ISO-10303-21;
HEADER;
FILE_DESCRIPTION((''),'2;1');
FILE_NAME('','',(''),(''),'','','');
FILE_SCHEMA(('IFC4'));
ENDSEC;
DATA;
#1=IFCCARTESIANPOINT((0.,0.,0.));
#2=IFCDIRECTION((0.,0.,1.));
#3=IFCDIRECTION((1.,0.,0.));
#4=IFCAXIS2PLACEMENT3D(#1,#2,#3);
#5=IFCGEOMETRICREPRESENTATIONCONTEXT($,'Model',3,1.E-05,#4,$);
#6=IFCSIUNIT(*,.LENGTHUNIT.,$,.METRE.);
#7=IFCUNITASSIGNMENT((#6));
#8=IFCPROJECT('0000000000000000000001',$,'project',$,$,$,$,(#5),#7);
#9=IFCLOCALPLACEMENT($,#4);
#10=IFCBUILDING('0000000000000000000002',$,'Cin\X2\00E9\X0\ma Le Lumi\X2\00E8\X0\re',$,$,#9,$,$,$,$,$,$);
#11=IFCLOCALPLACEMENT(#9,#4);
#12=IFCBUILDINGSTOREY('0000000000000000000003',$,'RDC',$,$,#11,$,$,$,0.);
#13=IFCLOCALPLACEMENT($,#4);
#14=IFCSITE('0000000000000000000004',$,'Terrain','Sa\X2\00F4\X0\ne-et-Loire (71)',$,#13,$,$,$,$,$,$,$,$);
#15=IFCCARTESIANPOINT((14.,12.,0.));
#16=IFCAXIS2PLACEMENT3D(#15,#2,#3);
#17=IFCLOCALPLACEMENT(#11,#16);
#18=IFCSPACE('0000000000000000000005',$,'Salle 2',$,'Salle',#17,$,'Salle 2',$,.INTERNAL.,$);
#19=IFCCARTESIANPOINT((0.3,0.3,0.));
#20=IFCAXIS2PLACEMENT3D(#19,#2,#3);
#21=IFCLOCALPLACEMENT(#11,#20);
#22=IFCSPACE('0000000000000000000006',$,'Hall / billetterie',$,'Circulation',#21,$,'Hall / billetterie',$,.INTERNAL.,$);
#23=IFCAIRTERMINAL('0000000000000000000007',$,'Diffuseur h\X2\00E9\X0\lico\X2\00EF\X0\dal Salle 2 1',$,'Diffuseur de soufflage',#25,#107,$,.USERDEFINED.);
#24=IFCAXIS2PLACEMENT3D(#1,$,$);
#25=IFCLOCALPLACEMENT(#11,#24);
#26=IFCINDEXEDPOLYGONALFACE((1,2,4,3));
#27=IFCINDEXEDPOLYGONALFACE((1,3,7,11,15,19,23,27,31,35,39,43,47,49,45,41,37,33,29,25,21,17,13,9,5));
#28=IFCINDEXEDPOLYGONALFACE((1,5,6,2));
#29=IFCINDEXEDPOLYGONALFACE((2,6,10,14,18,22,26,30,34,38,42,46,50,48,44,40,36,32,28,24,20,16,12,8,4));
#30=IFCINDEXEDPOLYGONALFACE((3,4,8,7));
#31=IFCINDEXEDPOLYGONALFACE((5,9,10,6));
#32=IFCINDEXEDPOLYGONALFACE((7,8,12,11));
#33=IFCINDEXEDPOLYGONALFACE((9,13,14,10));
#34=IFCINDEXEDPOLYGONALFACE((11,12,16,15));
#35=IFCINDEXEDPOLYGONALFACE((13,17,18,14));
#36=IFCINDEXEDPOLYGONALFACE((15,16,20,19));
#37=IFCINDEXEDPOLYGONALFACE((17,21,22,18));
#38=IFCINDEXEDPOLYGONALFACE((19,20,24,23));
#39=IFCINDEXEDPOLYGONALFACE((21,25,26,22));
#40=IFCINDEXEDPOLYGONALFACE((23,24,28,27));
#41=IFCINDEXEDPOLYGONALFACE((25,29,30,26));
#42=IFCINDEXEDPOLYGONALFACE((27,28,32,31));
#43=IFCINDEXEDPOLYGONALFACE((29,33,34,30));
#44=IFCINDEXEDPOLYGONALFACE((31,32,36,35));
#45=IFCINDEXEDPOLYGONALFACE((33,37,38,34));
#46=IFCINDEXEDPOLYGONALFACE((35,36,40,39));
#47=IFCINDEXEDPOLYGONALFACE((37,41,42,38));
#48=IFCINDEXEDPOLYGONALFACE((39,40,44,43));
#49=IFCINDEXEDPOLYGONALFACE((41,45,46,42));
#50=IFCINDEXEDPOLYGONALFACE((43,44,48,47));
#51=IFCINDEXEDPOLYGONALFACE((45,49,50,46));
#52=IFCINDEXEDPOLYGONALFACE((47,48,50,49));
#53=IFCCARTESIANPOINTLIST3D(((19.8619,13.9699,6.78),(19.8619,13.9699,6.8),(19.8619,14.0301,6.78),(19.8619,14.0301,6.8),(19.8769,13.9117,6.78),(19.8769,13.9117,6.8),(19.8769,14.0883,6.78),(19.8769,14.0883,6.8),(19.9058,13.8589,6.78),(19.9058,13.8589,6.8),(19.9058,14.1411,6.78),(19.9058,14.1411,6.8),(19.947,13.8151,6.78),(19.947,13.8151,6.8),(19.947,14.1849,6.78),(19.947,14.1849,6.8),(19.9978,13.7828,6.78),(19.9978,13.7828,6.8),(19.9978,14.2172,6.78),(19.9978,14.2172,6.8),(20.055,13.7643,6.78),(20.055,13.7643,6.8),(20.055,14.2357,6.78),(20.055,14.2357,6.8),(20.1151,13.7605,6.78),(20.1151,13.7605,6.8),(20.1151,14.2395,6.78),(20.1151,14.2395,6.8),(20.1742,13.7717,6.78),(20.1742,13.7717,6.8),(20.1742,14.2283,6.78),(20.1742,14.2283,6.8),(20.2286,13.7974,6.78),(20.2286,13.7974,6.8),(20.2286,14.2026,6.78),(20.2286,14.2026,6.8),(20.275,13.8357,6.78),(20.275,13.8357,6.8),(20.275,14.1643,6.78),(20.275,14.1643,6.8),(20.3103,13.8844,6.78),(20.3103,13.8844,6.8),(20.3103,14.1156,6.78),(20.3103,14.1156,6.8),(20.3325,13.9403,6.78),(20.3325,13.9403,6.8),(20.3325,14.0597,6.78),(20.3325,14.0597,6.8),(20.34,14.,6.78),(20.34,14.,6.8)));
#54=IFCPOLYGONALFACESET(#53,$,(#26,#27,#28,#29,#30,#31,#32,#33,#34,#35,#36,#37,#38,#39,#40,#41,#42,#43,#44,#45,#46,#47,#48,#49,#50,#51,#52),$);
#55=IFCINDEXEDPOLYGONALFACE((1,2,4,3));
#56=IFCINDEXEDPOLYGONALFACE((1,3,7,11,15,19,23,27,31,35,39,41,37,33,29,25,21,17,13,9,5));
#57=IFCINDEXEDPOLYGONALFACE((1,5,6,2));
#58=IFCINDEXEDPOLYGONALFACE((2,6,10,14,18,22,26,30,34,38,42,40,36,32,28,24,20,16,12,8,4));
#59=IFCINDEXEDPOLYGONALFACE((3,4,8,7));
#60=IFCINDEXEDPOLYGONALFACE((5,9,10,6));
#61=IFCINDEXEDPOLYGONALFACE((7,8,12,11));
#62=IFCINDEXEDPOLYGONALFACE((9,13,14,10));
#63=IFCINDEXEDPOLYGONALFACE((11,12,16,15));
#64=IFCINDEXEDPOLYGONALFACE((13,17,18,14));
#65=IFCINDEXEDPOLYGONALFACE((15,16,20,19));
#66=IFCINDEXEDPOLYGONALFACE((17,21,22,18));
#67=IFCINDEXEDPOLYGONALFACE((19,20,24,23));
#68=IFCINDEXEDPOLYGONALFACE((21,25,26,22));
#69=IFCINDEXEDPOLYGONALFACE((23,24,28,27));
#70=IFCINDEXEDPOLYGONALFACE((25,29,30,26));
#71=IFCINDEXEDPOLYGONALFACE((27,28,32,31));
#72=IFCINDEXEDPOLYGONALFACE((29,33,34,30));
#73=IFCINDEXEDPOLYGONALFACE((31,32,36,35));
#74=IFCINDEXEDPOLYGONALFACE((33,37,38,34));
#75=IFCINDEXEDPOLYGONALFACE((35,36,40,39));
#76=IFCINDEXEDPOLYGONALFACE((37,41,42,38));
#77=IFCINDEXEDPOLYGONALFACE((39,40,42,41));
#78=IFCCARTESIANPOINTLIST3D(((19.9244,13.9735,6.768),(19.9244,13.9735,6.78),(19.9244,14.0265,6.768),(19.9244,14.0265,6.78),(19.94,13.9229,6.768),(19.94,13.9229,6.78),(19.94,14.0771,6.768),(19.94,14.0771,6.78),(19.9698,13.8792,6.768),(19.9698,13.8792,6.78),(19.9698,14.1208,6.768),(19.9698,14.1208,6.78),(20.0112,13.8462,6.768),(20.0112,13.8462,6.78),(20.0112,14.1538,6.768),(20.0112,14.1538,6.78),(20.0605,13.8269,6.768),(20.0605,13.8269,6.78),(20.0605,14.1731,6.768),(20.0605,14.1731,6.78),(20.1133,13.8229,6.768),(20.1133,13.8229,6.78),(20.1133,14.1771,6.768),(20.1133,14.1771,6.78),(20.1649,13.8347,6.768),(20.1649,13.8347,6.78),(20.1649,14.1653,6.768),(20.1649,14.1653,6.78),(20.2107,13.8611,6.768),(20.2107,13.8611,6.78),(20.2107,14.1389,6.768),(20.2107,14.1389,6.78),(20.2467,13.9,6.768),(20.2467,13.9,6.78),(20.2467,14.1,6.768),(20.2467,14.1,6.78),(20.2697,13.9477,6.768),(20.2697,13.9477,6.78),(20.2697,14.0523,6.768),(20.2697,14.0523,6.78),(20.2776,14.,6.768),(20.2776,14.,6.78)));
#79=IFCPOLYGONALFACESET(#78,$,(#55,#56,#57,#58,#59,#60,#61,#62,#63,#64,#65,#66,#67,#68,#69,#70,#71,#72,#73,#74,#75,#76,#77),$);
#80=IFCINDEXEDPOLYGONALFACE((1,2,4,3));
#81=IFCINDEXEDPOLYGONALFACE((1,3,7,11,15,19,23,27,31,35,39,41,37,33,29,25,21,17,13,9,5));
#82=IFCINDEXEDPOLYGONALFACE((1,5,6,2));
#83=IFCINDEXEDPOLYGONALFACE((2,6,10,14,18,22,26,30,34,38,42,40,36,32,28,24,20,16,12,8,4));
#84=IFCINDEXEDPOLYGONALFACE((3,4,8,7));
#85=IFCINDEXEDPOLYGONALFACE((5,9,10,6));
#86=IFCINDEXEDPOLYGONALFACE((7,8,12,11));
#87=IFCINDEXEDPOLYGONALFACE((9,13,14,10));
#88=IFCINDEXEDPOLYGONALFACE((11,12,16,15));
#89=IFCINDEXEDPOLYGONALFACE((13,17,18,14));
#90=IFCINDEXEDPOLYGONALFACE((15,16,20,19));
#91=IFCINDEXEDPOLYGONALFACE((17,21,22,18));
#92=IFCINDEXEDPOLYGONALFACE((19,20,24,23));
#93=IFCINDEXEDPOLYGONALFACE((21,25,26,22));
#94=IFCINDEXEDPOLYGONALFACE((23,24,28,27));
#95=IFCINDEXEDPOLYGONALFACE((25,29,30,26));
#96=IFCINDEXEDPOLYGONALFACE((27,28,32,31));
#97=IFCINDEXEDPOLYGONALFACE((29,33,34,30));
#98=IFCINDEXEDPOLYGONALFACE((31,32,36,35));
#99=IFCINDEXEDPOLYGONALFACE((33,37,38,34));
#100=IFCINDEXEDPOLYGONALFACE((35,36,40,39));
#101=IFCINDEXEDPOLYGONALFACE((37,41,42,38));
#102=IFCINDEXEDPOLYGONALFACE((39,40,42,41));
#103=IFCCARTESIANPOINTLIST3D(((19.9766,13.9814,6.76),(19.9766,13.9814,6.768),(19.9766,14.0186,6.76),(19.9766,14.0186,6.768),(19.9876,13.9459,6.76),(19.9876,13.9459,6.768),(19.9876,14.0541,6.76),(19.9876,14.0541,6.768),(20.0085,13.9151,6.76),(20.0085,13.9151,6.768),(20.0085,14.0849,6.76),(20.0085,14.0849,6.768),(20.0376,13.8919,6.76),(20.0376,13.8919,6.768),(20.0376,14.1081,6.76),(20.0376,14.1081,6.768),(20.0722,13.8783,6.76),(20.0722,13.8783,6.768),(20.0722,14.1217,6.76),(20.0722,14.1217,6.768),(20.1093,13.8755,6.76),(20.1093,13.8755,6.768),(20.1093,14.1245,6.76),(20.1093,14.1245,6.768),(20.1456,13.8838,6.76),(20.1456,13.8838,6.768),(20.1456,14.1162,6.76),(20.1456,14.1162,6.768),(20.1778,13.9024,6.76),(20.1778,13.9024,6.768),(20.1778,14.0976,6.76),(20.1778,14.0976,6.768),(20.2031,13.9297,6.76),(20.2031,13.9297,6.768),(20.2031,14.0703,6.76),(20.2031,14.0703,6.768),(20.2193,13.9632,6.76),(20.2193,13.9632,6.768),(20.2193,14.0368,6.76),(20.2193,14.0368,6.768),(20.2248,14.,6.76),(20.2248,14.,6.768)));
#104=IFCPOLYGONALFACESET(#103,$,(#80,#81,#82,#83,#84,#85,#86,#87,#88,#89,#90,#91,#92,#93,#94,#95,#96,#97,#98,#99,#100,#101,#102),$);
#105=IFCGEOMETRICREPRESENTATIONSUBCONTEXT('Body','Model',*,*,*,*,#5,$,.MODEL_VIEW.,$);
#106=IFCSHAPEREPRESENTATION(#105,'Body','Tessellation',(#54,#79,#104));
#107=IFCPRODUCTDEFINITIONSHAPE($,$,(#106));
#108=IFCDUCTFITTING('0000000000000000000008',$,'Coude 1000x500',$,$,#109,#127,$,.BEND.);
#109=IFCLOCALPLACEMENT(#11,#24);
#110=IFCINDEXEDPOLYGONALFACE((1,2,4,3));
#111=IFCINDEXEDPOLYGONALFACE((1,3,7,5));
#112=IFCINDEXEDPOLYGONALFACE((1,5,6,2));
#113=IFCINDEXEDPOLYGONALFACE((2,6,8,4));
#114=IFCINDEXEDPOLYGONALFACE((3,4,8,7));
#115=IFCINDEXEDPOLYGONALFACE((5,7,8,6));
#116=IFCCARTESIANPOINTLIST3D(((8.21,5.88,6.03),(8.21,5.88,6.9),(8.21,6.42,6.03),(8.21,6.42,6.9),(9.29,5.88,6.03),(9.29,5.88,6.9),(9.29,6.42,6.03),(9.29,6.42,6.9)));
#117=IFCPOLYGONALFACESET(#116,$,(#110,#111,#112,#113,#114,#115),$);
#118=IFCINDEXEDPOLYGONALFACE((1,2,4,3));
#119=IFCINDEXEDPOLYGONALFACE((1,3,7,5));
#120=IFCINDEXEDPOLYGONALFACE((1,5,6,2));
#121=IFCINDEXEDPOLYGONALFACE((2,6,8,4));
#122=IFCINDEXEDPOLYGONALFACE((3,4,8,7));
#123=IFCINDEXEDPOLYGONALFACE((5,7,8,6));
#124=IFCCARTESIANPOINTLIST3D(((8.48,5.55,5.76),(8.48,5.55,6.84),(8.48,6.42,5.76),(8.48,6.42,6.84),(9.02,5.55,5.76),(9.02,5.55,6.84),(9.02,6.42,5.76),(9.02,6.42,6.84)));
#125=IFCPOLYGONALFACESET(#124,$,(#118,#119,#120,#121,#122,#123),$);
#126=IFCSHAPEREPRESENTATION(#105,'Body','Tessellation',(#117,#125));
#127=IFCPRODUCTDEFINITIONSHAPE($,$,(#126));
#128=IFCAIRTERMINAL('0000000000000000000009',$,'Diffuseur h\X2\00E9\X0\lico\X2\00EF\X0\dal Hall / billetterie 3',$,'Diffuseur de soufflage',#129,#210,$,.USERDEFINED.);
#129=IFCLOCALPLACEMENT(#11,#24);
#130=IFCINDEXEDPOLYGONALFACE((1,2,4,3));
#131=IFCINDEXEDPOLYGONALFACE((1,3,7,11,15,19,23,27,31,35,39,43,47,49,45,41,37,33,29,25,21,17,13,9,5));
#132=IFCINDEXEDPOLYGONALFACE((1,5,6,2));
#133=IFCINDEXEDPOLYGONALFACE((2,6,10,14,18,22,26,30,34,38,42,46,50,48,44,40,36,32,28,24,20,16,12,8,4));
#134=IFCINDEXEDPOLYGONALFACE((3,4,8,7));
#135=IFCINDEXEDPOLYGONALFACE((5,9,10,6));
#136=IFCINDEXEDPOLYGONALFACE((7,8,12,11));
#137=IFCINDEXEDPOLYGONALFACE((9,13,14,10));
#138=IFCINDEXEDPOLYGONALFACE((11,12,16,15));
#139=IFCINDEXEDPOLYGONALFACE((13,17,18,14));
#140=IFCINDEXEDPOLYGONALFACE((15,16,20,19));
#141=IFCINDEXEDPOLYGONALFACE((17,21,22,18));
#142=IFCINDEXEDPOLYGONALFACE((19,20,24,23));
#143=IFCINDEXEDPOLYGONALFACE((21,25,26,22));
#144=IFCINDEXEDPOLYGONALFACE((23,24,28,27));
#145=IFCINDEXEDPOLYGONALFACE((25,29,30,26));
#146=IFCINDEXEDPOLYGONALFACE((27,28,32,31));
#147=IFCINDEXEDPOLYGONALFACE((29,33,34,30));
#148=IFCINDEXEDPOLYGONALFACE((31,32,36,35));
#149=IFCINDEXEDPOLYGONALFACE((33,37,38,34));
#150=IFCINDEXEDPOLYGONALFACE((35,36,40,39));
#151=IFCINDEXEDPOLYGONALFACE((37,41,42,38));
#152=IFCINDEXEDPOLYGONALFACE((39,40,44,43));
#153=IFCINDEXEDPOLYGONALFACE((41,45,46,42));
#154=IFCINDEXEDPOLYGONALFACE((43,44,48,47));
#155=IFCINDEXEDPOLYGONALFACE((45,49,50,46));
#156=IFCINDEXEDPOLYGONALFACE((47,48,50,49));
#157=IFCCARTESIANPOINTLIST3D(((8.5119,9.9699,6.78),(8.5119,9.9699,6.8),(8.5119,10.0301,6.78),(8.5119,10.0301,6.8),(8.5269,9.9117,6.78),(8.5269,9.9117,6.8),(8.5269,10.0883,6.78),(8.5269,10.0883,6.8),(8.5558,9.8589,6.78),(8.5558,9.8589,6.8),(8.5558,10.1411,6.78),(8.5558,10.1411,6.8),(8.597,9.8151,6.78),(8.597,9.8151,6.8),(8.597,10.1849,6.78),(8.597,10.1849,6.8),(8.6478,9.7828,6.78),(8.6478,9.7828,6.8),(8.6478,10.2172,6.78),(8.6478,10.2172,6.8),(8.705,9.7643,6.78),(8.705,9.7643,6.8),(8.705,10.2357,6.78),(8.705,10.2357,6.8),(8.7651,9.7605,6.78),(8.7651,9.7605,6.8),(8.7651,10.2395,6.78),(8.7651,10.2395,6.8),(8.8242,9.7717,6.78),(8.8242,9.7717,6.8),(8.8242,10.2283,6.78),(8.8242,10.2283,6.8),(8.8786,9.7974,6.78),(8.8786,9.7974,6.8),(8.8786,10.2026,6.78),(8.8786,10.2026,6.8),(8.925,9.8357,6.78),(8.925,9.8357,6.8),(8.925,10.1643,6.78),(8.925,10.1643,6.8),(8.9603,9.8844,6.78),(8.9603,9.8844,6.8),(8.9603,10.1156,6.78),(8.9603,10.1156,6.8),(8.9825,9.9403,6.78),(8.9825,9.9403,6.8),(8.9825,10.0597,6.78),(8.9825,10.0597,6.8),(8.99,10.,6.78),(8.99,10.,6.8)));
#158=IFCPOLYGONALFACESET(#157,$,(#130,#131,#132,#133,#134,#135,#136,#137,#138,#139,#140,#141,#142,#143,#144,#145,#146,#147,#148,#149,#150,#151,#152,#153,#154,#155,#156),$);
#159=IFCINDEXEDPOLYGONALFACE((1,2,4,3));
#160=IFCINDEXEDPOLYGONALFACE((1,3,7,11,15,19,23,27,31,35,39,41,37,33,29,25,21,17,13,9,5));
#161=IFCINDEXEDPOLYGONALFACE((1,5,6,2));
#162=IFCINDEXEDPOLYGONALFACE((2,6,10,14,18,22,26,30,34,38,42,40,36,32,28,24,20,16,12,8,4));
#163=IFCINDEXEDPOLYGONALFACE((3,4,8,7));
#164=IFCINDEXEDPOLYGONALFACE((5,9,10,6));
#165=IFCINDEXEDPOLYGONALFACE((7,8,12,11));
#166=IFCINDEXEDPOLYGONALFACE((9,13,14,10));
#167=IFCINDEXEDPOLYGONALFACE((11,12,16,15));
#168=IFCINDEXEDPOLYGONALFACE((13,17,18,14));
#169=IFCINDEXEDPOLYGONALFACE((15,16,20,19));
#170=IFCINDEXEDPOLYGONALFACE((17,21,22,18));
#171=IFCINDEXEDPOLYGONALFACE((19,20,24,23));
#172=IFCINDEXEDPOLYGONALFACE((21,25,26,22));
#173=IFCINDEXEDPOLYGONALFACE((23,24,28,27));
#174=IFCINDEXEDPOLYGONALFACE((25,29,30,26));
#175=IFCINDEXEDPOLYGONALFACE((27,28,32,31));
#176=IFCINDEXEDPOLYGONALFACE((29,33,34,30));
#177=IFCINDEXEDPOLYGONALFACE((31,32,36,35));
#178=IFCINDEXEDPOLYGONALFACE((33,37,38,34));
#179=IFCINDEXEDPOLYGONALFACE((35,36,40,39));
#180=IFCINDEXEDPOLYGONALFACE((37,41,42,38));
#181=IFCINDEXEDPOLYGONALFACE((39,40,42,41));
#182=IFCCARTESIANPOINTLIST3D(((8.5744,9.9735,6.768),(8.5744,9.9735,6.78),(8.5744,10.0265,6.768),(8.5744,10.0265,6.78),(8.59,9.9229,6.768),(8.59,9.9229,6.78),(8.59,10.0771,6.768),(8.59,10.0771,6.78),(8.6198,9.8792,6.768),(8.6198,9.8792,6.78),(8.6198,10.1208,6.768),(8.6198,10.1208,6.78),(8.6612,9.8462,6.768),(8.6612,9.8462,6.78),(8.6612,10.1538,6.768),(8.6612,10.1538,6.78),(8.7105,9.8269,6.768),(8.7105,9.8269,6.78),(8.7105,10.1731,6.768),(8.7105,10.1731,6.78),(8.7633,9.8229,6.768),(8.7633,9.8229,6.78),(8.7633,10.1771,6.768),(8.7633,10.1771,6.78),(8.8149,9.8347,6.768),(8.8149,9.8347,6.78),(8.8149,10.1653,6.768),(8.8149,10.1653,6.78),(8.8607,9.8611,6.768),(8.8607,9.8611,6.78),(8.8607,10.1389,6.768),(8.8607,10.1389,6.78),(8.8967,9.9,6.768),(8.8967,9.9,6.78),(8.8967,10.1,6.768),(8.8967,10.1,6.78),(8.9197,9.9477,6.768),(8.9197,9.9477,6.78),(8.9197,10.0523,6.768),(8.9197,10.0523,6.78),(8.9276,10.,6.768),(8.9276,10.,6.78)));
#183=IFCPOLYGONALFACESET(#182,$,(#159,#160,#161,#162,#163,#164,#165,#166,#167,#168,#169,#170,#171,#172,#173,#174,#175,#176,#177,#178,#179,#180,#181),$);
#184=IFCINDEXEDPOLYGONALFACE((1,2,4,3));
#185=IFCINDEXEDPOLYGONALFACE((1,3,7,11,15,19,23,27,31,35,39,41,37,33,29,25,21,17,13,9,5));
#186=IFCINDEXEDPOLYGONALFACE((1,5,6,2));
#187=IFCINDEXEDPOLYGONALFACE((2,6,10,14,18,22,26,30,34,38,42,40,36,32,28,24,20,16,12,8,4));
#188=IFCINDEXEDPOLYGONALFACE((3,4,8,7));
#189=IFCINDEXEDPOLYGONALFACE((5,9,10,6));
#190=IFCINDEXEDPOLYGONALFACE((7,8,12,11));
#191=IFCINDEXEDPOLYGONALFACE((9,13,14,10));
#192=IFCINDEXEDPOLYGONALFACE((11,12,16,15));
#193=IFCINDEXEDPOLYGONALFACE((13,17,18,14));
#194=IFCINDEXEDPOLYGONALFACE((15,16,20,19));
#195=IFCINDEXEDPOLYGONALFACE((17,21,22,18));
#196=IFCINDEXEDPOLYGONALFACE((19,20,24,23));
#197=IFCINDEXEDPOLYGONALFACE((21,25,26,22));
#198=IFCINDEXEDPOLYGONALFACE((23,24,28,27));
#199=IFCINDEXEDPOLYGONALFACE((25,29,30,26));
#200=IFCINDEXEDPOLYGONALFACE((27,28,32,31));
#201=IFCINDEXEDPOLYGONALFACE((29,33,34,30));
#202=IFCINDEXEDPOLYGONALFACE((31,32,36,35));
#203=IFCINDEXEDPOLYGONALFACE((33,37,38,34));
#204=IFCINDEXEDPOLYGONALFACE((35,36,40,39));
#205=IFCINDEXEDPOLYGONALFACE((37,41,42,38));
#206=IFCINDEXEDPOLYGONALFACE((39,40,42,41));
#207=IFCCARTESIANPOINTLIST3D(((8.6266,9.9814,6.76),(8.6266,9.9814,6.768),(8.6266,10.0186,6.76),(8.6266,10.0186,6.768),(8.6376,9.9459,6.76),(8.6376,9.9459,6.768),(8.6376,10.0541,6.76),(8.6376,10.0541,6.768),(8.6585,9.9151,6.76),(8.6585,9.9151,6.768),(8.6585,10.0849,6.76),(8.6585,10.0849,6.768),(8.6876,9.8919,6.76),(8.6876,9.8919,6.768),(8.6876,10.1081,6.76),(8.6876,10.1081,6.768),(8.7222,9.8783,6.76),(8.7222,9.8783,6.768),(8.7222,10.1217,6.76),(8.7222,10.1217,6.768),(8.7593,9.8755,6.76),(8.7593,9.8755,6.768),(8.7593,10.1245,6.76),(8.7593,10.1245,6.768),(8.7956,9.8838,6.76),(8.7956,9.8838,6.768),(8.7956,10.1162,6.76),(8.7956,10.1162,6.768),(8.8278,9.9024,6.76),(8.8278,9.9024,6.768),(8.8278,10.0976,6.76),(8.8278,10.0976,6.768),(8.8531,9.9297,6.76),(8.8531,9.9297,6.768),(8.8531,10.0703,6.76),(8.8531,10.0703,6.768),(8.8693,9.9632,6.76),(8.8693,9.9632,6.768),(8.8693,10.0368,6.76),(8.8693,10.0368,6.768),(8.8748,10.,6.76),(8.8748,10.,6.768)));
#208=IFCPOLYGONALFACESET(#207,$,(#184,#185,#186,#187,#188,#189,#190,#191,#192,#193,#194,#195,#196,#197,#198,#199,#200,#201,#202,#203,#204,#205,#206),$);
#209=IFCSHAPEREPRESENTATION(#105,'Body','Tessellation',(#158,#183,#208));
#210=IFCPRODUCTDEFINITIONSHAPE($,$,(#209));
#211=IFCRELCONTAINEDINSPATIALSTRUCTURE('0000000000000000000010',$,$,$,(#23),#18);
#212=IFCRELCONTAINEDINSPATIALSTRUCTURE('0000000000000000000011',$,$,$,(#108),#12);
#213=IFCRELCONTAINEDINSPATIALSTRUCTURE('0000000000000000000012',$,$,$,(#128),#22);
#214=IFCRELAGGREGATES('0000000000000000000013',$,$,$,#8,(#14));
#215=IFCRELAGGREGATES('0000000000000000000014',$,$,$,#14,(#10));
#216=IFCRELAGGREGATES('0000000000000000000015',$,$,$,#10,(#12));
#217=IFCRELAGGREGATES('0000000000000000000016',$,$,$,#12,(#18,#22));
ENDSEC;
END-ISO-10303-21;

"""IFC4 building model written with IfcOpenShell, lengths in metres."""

from ifc_helpers import new_model, si_unit, frame, origin_with_axes, origin_2d, place, context, subcontext, project, spatial, rectangle, circle, extrude, element, save


model = new_model("IFC4")

# Units and contexts
model_context = context("Model", 3, precision=1e-05, world=origin_with_axes())
body_context = subcontext(model_context, "Body", "Model", "MODEL_VIEW")
ifc_project = project(units=[si_unit("LENGTHUNIT", "METRE")], contexts=[model_context])

# Site, building, storey
site_placement = place(None, origin_with_axes())
site = spatial("IfcSite", under=ifc_project, at=site_placement, Name="Terrain", Description="Saône-et-Loire (71)")
building_placement = place(None, origin_with_axes())
building = spatial("IfcBuilding", under=site, at=building_placement, Name="Cinéma Le Lumière")
storey_placement = place(building_placement, origin_with_axes())
storey = spatial("IfcBuildingStorey", under=building, at=storey_placement, Name="RDC", Elevation=0.0)

# Shared definitions
space_1_placement = place(storey_placement, frame((14.0, 12.0, 0.0), z_axis=(0.0, 0.0, 1.0), x_axis=(1.0, 0.0, 0.0)))
space_1 = spatial("IfcSpace", under=storey, at=space_1_placement, Name="Salle 2", ObjectType="Salle", LongName="Salle 2", PredefinedType="INTERNAL")

# Air terminal
for number, where, z_axis, x_axis, name in (
    (1, (6.1, 2.0, 6.76), (0.0, 0.0, 1.0), (1.0, 0.0, 0.0), "Diffuseur hélicoïdal Salle 2 1"),
):
    element("IfcAirTerminal", number, at=place(space_1_placement, frame(where, z_axis=z_axis, x_axis=x_axis)), inside=space_1, Name=name, ObjectType="Diffuseur de soufflage", PredefinedType="USERDEFINED", context=body_context, shape_type="SweptSolid", body=[
        extrude(circle(Radius=0.24), frame((0.0, 0.0, 0.02), z_axis=(0.0, 0.0, 1.0), x_axis=(1.0, 0.0, 0.0)), (0.0, 0.0, 1.0), 0.02),
        extrude(circle(Radius=0.1776), frame((0.0, 0.0, 0.008), z_axis=(0.0, 0.0, 1.0), x_axis=(1.0, 0.0, 0.0)), (0.0, 0.0, 1.0), 0.012),
        extrude(circle(Radius=0.1248), origin_with_axes(), (0.0, 0.0, 1.0), 0.008),
    ])

# Duct fitting
duct_fitting_1_placement = place(storey_placement, frame((8.75, 6.15, 6.3), z_axis=(0.0, 0.0, 1.0), x_axis=(1.0, 0.0, 0.0)))
element("IfcDuctFitting", 2, at=duct_fitting_1_placement, inside=storey, Name="Coude 1000x500", PredefinedType="BEND", context=body_context, shape_type="SweptSolid", body=[
    extrude(rectangle(XDim=1.08, YDim=0.54, at=origin_2d()), frame((0.0, 0.0, -0.27), z_axis=(0.0, 0.0, 1.0), x_axis=(1.0, 0.0, 0.0)), (0.0, 0.0, 1.0), 0.87),
    extrude(rectangle(XDim=1.08, YDim=0.54, at=origin_2d()), frame((0.0, 0.27, 0.0), z_axis=(0.0, -1.0, 0.0), x_axis=(0.0, 0.0, 1.0)), (0.0, 0.0, 1.0), 0.87),
])

# Shared definitions
space_2_placement = place(storey_placement, frame((0.3, 0.3, 0.0), z_axis=(0.0, 0.0, 1.0), x_axis=(1.0, 0.0, 0.0)))
space_2 = spatial("IfcSpace", under=storey, at=space_2_placement, Name="Hall / billetterie", ObjectType="Circulation", LongName="Hall / billetterie", PredefinedType="INTERNAL")

# Air terminal
air_terminal_1_placement = place(space_2_placement, frame((8.45, 9.7, 6.76), z_axis=(0.0, 0.0, 1.0), x_axis=(1.0, 0.0, 0.0)))
element("IfcAirTerminal", 3, at=air_terminal_1_placement, inside=space_2, Name="Diffuseur hélicoïdal Hall / billetterie 3", ObjectType="Diffuseur de soufflage", PredefinedType="USERDEFINED", context=body_context, shape_type="SweptSolid", body=[
    extrude(circle(Radius=0.24), frame((0.0, 0.0, 0.02), z_axis=(0.0, 0.0, 1.0), x_axis=(1.0, 0.0, 0.0)), (0.0, 0.0, 1.0), 0.02),
    extrude(circle(Radius=0.1776), frame((0.0, 0.0, 0.008), z_axis=(0.0, 0.0, 1.0), x_axis=(1.0, 0.0, 0.0)), (0.0, 0.0, 1.0), 0.012),
    extrude(circle(Radius=0.1248), origin_with_axes(), (0.0, 0.0, 1.0), 0.008),
])

save(model, "model.ifc")
